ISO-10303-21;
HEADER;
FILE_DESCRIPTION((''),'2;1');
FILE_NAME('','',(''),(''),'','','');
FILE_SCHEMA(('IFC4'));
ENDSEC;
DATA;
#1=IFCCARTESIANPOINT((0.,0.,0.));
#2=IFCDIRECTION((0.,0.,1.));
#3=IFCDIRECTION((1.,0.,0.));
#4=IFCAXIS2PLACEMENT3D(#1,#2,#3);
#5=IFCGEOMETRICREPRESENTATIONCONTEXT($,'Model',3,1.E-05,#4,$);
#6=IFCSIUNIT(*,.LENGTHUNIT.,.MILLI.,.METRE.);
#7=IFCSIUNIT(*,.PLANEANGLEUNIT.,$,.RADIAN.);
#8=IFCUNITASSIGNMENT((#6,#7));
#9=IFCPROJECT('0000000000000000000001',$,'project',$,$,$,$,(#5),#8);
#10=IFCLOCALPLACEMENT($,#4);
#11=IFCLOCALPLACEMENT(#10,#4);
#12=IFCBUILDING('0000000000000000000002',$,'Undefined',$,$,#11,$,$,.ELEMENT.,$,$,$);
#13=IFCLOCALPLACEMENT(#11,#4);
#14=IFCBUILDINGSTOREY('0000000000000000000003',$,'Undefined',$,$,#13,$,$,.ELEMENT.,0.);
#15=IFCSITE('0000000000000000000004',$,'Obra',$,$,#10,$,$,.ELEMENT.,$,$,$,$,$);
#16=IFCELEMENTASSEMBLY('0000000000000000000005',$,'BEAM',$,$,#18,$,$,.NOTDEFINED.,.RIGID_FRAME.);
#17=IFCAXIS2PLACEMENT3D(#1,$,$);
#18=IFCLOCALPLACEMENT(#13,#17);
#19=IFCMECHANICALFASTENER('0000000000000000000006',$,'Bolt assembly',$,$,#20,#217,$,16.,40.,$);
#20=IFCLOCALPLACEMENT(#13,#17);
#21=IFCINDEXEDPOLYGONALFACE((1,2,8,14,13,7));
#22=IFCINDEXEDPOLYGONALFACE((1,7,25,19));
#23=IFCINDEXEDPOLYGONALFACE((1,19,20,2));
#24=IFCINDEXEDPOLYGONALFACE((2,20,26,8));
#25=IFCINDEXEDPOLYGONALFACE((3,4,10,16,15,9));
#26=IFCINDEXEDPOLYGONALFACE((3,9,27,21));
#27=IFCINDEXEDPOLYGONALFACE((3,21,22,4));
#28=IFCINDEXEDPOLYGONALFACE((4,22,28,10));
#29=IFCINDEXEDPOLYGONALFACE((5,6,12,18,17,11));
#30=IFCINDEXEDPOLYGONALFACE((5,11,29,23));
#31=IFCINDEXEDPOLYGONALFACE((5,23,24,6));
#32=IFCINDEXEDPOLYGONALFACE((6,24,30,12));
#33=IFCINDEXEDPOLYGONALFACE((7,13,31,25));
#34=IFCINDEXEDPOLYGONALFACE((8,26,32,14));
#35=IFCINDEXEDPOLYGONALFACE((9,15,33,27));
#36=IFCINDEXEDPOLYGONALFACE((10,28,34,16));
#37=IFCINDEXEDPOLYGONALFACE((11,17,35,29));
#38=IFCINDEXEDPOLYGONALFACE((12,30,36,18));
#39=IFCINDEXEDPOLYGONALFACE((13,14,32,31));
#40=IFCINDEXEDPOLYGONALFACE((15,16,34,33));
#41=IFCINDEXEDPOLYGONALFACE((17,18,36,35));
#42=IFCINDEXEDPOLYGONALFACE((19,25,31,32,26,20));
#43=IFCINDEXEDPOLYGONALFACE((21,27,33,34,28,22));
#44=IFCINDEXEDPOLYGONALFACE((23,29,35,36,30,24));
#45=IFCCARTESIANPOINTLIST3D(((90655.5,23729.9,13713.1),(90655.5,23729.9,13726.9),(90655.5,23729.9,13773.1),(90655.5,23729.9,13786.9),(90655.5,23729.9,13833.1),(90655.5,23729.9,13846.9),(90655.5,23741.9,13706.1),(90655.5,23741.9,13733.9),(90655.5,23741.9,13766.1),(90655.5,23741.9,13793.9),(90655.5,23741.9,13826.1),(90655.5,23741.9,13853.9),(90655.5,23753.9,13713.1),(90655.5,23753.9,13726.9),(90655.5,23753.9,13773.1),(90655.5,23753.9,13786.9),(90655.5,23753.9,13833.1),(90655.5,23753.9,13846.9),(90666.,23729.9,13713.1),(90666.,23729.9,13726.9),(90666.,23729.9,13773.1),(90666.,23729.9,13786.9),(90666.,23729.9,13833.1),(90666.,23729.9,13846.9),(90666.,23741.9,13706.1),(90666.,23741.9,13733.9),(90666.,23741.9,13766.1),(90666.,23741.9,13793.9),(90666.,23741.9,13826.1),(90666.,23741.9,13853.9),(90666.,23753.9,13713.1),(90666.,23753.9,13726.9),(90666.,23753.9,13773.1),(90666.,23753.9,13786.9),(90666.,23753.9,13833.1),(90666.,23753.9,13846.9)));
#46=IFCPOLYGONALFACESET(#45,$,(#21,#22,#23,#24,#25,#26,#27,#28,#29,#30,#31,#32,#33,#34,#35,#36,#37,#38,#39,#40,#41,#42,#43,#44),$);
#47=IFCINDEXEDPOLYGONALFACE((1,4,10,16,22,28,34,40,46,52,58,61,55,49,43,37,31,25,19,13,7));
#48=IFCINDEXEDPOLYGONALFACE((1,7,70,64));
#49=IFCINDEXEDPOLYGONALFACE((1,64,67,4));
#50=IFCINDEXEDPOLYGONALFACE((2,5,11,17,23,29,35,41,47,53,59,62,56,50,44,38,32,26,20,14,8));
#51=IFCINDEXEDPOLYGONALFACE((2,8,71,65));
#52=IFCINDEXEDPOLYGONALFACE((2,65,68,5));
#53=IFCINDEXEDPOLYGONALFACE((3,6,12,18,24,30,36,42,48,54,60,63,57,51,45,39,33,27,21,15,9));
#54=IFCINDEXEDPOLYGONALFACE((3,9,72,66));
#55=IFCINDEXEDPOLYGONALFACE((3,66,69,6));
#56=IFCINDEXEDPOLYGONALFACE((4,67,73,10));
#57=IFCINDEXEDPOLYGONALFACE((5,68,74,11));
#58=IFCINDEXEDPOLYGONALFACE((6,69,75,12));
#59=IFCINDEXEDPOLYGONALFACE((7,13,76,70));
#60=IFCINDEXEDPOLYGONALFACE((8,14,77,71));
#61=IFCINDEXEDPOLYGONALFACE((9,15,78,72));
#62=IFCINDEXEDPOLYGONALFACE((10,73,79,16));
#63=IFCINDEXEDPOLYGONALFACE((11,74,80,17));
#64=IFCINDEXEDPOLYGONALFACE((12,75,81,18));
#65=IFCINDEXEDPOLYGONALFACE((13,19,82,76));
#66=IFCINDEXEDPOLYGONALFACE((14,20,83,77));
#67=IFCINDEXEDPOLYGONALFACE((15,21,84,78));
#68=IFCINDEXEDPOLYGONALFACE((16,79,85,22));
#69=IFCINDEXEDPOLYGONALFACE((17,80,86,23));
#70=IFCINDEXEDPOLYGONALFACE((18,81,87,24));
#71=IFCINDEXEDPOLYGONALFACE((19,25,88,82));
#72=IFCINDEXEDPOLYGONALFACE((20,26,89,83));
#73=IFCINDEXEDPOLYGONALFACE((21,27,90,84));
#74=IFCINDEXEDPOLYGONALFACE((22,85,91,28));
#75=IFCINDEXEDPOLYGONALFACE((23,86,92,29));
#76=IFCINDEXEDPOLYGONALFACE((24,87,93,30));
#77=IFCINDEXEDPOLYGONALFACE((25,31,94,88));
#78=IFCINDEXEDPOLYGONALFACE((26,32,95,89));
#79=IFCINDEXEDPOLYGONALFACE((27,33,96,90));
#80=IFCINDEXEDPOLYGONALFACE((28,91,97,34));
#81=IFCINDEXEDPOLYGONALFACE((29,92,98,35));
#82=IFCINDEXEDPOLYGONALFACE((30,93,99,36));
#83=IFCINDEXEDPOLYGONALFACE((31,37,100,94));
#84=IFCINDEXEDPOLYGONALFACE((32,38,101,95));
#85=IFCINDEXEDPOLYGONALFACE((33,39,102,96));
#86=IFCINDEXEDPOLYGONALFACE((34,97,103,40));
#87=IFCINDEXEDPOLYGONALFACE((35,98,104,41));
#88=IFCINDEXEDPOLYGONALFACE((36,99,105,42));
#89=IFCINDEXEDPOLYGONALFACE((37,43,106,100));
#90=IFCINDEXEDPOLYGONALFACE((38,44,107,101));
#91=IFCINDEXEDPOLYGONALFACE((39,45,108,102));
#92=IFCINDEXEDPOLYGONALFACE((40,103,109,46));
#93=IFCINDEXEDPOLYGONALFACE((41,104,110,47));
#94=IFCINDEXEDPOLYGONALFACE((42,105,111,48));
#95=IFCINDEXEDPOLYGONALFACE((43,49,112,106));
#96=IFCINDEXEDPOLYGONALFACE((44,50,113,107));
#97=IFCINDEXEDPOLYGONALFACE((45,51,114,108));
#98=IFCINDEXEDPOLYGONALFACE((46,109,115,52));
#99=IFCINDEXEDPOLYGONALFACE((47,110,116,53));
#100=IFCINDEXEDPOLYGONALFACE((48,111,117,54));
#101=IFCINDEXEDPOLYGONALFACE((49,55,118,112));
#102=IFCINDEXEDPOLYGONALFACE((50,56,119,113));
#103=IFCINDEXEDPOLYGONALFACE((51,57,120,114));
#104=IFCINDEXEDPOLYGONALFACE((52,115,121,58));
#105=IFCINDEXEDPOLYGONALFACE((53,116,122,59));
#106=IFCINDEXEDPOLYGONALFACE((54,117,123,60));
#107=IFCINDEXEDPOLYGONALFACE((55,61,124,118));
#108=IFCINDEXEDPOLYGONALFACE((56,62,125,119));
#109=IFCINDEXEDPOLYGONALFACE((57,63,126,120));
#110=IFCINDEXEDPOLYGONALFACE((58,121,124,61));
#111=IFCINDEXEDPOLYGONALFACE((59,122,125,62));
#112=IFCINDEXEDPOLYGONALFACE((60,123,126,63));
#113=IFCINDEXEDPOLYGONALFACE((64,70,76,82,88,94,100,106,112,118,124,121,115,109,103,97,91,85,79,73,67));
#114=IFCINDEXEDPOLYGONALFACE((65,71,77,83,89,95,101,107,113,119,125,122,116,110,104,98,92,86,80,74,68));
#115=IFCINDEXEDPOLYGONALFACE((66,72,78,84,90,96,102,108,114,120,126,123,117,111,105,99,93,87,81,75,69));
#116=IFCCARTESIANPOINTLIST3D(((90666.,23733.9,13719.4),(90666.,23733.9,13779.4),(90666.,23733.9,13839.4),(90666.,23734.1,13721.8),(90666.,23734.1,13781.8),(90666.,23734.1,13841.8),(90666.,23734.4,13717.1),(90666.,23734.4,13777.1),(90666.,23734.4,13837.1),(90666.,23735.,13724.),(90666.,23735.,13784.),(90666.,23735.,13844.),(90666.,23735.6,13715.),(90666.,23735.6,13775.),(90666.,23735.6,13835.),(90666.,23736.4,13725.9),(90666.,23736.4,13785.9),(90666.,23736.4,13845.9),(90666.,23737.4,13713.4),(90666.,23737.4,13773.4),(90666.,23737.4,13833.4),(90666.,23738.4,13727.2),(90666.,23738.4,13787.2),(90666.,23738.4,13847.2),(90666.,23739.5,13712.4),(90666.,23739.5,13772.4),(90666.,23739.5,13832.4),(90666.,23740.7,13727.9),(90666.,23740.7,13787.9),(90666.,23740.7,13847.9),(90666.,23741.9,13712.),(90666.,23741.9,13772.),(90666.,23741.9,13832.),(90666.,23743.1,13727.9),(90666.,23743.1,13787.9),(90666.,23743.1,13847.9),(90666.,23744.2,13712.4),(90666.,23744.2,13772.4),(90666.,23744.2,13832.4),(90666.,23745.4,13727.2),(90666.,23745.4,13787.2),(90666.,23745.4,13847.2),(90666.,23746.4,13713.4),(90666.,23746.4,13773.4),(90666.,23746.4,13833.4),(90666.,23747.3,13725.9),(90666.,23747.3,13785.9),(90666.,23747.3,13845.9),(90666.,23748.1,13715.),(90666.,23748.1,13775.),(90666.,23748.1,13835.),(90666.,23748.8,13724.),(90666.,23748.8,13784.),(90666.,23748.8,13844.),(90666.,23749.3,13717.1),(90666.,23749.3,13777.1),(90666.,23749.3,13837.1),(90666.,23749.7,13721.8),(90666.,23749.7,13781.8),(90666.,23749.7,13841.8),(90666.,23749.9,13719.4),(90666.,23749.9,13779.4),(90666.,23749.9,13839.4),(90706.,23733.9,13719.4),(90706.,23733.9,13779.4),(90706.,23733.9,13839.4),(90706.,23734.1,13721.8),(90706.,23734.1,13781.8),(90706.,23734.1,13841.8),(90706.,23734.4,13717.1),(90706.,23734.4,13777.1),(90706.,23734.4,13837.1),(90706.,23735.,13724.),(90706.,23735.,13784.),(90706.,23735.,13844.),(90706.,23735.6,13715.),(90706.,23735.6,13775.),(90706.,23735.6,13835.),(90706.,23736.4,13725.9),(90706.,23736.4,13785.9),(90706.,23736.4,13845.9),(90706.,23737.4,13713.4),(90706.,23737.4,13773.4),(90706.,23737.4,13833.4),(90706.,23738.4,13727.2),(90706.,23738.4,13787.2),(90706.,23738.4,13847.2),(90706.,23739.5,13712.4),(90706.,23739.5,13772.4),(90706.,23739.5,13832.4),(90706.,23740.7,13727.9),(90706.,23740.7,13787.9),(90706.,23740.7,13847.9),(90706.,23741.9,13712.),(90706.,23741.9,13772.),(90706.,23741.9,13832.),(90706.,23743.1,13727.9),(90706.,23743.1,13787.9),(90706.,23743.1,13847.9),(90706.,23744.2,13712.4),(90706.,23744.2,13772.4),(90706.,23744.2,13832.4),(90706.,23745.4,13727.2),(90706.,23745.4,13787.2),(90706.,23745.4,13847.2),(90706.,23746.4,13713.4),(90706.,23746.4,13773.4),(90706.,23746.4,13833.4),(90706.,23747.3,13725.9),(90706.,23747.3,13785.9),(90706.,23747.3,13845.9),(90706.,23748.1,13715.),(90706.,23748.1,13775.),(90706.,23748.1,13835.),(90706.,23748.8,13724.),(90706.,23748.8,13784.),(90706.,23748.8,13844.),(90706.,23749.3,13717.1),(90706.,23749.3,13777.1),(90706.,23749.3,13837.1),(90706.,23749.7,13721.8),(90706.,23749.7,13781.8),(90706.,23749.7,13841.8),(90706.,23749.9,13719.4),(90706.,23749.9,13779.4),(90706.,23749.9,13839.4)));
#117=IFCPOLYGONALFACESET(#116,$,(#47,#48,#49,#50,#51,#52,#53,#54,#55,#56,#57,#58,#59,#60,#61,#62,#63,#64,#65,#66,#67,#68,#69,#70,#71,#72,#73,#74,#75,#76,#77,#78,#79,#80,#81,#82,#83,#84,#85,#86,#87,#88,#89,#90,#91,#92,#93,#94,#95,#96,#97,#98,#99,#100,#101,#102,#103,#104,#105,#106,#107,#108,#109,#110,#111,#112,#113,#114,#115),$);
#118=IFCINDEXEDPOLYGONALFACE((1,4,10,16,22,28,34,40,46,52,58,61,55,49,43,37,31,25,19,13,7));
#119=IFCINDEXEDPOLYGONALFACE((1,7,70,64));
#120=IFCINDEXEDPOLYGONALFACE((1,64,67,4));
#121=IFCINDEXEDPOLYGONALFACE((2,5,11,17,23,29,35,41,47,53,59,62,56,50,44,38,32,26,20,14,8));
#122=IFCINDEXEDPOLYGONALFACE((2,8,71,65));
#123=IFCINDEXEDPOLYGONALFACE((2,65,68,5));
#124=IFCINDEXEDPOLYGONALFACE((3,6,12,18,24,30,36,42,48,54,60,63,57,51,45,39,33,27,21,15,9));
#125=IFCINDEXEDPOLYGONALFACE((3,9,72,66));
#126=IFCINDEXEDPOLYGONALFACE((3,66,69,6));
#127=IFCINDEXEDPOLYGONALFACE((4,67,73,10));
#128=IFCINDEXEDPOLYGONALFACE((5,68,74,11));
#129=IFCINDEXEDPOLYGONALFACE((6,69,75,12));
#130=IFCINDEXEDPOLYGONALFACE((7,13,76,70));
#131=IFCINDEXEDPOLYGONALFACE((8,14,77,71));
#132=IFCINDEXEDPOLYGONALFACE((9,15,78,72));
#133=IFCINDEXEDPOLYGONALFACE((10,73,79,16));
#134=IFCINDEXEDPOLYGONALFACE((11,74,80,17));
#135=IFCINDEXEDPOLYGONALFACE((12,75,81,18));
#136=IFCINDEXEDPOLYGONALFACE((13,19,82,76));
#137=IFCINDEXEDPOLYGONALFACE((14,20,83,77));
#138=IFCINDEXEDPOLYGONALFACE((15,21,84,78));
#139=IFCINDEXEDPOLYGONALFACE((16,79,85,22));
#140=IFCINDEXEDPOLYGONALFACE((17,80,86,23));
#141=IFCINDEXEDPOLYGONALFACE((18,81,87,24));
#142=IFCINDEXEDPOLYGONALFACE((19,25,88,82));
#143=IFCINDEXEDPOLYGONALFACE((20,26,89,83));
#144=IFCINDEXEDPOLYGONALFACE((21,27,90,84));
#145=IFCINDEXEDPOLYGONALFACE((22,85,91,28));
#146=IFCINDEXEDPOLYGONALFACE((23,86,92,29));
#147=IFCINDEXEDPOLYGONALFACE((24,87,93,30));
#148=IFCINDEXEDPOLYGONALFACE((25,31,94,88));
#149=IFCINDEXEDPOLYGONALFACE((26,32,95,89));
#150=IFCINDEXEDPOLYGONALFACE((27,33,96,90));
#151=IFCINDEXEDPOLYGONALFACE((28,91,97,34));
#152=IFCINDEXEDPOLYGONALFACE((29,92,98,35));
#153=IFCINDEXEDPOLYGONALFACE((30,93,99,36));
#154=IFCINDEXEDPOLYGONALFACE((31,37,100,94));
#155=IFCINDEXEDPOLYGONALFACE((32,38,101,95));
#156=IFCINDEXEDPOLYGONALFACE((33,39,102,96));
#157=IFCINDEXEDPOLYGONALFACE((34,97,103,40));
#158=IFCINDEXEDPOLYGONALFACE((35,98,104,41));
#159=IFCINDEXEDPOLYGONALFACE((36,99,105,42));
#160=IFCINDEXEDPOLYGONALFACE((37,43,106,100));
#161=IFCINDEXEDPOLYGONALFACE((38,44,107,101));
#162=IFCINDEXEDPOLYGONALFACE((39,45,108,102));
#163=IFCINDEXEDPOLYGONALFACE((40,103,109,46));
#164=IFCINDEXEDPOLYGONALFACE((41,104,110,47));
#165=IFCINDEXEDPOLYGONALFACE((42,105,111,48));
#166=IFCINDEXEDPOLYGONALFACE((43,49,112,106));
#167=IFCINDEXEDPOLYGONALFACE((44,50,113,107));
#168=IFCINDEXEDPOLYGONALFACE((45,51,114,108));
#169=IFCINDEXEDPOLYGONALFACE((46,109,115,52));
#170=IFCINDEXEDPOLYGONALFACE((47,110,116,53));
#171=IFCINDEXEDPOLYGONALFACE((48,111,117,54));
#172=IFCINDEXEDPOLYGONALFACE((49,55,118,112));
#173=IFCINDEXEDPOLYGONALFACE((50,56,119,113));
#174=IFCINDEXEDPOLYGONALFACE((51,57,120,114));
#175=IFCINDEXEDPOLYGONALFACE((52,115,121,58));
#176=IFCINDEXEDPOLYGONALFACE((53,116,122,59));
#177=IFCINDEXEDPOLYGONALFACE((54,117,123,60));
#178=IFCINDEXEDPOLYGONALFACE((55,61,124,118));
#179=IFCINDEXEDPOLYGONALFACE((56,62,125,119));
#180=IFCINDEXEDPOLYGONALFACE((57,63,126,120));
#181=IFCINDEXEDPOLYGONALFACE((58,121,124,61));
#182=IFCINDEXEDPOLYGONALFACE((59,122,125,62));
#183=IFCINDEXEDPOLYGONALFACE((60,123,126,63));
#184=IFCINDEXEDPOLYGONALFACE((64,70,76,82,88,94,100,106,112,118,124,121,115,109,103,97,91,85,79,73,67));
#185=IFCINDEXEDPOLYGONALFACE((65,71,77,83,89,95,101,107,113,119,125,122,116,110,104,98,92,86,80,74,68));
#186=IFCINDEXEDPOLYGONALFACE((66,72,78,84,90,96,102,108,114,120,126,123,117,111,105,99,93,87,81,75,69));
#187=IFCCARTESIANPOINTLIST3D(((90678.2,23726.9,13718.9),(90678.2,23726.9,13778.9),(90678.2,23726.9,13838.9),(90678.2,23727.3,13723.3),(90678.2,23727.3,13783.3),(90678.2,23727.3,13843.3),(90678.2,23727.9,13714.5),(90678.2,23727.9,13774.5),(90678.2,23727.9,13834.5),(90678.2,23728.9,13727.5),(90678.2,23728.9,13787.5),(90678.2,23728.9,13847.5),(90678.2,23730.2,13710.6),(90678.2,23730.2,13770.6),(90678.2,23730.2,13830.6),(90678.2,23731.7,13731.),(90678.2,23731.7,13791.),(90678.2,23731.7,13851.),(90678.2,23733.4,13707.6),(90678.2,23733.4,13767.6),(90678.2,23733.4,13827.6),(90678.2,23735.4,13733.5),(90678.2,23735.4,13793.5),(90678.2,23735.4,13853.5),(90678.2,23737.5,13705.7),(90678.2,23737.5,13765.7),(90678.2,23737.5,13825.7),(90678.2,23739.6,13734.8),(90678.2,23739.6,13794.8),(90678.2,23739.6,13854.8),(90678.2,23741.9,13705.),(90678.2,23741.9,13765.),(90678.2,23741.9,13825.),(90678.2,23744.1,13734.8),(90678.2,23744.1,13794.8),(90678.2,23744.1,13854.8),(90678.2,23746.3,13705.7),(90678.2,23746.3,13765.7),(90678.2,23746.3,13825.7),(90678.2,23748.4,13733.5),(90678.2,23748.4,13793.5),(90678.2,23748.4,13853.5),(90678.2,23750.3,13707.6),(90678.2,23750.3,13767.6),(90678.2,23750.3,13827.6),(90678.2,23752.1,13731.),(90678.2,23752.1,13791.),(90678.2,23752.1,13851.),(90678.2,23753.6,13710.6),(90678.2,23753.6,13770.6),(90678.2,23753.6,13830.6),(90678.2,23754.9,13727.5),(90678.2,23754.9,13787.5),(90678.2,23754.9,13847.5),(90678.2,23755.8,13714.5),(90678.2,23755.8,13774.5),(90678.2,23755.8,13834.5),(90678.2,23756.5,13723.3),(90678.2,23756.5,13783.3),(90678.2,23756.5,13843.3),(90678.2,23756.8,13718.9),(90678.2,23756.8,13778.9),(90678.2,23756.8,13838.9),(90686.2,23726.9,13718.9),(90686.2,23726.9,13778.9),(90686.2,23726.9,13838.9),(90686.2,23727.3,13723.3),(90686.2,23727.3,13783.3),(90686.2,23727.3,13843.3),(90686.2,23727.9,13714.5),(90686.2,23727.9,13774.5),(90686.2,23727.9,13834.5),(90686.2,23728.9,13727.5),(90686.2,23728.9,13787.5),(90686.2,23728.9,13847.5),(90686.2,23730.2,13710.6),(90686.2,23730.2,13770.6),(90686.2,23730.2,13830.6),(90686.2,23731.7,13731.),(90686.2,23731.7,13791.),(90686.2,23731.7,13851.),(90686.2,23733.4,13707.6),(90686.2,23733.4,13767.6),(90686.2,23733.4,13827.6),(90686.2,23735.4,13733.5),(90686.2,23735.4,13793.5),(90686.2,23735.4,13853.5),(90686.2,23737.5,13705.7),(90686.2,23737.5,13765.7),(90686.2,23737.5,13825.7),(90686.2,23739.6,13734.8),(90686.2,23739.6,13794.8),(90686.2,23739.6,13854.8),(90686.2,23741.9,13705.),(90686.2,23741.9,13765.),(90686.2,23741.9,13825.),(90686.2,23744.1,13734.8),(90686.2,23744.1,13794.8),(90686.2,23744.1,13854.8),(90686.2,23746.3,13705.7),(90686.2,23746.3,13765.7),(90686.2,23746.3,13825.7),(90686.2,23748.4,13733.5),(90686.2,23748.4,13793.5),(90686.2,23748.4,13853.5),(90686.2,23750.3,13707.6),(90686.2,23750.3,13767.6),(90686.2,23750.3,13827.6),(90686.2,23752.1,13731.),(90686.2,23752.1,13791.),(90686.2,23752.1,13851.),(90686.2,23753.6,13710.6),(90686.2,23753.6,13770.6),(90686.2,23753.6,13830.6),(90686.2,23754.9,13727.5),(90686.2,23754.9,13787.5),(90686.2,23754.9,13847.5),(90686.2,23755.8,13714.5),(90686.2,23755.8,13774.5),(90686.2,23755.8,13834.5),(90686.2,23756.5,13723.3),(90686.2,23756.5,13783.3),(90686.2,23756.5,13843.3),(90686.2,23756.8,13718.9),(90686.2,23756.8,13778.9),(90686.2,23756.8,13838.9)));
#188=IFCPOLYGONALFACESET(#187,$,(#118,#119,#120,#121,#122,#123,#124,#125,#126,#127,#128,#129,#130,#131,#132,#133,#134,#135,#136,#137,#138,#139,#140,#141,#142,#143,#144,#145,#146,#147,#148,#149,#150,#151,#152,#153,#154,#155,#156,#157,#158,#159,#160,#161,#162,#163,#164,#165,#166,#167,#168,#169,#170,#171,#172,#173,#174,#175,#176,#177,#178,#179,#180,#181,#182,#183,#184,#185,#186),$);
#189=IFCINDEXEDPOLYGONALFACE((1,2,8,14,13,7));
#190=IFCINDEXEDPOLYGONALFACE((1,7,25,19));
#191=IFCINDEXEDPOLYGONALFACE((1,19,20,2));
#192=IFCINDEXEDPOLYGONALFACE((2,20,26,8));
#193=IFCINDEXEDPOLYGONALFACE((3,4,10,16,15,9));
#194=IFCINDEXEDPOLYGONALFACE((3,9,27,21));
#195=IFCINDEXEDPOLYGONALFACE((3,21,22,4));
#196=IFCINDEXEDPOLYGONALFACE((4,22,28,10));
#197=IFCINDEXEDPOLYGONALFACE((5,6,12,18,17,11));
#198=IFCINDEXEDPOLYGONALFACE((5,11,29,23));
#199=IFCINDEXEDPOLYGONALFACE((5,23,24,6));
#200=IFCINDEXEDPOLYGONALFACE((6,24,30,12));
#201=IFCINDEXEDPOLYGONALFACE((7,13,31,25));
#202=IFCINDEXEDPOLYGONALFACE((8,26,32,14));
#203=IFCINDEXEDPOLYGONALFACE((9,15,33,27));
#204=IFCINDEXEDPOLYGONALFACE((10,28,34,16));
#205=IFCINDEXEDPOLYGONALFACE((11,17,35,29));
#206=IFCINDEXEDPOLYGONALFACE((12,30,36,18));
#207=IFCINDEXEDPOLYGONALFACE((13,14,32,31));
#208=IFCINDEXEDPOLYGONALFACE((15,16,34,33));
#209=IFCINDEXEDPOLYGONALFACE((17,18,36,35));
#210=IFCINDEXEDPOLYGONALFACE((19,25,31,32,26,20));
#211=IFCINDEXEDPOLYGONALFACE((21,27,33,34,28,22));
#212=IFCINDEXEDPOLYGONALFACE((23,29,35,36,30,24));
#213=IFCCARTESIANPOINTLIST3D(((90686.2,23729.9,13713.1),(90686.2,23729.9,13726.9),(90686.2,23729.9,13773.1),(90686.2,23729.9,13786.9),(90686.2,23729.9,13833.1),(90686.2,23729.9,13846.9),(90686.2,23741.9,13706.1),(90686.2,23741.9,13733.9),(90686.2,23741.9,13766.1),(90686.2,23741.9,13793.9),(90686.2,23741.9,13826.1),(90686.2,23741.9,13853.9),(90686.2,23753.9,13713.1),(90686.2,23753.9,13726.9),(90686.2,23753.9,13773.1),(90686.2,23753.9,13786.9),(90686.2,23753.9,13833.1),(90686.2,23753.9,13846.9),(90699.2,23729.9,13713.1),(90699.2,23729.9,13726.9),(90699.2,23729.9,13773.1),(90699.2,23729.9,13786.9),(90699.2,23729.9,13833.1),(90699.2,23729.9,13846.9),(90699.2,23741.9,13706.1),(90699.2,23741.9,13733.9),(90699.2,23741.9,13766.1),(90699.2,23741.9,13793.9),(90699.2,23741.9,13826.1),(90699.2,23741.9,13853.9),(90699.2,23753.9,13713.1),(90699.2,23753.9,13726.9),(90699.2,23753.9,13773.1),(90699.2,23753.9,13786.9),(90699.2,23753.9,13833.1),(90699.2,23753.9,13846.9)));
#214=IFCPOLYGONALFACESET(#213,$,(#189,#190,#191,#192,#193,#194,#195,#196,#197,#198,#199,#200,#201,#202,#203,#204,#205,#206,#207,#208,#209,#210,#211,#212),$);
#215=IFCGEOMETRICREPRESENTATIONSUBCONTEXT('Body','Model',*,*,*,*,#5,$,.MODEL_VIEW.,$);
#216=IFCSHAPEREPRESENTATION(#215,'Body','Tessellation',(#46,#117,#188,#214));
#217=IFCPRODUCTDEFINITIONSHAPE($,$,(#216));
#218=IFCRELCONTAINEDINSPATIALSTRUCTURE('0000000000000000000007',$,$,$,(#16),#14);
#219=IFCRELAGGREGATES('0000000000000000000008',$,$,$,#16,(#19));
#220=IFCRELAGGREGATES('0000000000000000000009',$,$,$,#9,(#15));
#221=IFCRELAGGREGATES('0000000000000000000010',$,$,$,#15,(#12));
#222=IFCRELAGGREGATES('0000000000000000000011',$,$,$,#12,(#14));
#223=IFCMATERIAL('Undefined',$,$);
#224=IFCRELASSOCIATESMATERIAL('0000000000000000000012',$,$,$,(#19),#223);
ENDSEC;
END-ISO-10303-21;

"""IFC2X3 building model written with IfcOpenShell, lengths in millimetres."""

from ifc_helpers import new_model, si_unit, frame, origin_with_axes, origin_2d_with_axis, place, context, subcontext, project, spatial, polyline, circle, outline, extrude, source, transform, mapped, material, element, aggregate, save


model = new_model("IFC2X3")

# Units and contexts
model_context = context("Model", 3, precision=1e-05, world=origin_with_axes())
body_context = subcontext(model_context, "Body", "Model", "MODEL_VIEW")
ifc_project = project(units=[si_unit("LENGTHUNIT", "METRE", prefix="MILLI"), si_unit("PLANEANGLEUNIT", "RADIAN")], contexts=[model_context])

# Site, building, storey
site_placement = place(None, origin_with_axes())
site = spatial("IfcSite", under=ifc_project, at=site_placement, Name="Obra", CompositionType="ELEMENT")
building_placement = place(site_placement, origin_with_axes())
building = spatial("IfcBuilding", under=site, at=building_placement, Name="Undefined", CompositionType="ELEMENT")
storey_placement = place(building_placement, origin_with_axes())
storey = spatial("IfcBuildingStorey", under=building, at=storey_placement, Name="Undefined", CompositionType="ELEMENT", Elevation=0.0)

# Shared definitions
ifc_material_1 = material(Name="Undefined")
shared_shape_1 = source(origin_with_axes(), body_context, "Body", "SweptSolid", [
    extrude(outline(polyline([(13.9, 0.0), (6.9, 12.0), (-6.9, 12.0), (-13.9, 0.0), (-6.9, -12.0), (6.9, -12.0), (13.9, 0.0)])), frame((0.0, -19.7, 0.0), z_axis=(0.0, 1.0, 0.0), x_axis=(1.0, 0.0, 0.0)), (0.0, 0.0, 1.0), 10.6),
    extrude(circle(Radius=8.0, at=origin_2d_with_axis()), frame((0.0, -9.1, 0.0), z_axis=(0.0, 1.0, 0.0), x_axis=(1.0, 0.0, 0.0)), (0.0, 0.0, 1.0), 40.0),
    extrude(circle(Radius=15.0, at=origin_2d_with_axis()), frame((0.0, 3.1, 0.0), z_axis=(0.0, 1.0, 0.0), x_axis=(1.0, 0.0, 0.0)), (0.0, 0.0, 1.0), 8.0),
    extrude(outline(polyline([(13.9, 0.0), (6.9, 12.0), (-6.9, 12.0), (-13.9, 0.0), (-6.9, -12.0), (6.9, -12.0), (13.9, 0.0)])), frame((0.0, 11.1, 0.0), z_axis=(0.0, 1.0, 0.0), x_axis=(1.0, 0.0, 0.0)), (0.0, 0.0, 1.0), 13.0),
])

# Element assembly, mechanical fastener
assembly_1_placement = place(storey_placement, origin_with_axes())
assembly_1 = element("IfcElementAssembly", 1, at=assembly_1_placement, inside=storey, Name="BEAM", AssemblyPlace="NOTDEFINED", PredefinedType="RIGID_FRAME")
mechanical_fastener_1_placement = place(assembly_1_placement, frame((90675.1, 23791.9, 13885.4), z_axis=(0.0, -1.0, 0.0), x_axis=(0.0, 0.0, -1.0)))
mechanical_fastener_1 = element("IfcMechanicalFastener", 2, at=mechanical_fastener_1_placement, material=ifc_material_1, Name="Bolt assembly", NominalDiameter=16.0, NominalLength=40.0, context=body_context, shape_type="MappedRepresentation", body=[
    mapped(shared_shape_1, transform((165.4, 0.0, 50.0))),
    mapped(shared_shape_1, transform((105.4, 0.0, 50.0))),
    mapped(shared_shape_1, transform((45.4, 0.0, 50.0))),
])
aggregate(assembly_1, [mechanical_fastener_1])

save(model, "model.ifc")
